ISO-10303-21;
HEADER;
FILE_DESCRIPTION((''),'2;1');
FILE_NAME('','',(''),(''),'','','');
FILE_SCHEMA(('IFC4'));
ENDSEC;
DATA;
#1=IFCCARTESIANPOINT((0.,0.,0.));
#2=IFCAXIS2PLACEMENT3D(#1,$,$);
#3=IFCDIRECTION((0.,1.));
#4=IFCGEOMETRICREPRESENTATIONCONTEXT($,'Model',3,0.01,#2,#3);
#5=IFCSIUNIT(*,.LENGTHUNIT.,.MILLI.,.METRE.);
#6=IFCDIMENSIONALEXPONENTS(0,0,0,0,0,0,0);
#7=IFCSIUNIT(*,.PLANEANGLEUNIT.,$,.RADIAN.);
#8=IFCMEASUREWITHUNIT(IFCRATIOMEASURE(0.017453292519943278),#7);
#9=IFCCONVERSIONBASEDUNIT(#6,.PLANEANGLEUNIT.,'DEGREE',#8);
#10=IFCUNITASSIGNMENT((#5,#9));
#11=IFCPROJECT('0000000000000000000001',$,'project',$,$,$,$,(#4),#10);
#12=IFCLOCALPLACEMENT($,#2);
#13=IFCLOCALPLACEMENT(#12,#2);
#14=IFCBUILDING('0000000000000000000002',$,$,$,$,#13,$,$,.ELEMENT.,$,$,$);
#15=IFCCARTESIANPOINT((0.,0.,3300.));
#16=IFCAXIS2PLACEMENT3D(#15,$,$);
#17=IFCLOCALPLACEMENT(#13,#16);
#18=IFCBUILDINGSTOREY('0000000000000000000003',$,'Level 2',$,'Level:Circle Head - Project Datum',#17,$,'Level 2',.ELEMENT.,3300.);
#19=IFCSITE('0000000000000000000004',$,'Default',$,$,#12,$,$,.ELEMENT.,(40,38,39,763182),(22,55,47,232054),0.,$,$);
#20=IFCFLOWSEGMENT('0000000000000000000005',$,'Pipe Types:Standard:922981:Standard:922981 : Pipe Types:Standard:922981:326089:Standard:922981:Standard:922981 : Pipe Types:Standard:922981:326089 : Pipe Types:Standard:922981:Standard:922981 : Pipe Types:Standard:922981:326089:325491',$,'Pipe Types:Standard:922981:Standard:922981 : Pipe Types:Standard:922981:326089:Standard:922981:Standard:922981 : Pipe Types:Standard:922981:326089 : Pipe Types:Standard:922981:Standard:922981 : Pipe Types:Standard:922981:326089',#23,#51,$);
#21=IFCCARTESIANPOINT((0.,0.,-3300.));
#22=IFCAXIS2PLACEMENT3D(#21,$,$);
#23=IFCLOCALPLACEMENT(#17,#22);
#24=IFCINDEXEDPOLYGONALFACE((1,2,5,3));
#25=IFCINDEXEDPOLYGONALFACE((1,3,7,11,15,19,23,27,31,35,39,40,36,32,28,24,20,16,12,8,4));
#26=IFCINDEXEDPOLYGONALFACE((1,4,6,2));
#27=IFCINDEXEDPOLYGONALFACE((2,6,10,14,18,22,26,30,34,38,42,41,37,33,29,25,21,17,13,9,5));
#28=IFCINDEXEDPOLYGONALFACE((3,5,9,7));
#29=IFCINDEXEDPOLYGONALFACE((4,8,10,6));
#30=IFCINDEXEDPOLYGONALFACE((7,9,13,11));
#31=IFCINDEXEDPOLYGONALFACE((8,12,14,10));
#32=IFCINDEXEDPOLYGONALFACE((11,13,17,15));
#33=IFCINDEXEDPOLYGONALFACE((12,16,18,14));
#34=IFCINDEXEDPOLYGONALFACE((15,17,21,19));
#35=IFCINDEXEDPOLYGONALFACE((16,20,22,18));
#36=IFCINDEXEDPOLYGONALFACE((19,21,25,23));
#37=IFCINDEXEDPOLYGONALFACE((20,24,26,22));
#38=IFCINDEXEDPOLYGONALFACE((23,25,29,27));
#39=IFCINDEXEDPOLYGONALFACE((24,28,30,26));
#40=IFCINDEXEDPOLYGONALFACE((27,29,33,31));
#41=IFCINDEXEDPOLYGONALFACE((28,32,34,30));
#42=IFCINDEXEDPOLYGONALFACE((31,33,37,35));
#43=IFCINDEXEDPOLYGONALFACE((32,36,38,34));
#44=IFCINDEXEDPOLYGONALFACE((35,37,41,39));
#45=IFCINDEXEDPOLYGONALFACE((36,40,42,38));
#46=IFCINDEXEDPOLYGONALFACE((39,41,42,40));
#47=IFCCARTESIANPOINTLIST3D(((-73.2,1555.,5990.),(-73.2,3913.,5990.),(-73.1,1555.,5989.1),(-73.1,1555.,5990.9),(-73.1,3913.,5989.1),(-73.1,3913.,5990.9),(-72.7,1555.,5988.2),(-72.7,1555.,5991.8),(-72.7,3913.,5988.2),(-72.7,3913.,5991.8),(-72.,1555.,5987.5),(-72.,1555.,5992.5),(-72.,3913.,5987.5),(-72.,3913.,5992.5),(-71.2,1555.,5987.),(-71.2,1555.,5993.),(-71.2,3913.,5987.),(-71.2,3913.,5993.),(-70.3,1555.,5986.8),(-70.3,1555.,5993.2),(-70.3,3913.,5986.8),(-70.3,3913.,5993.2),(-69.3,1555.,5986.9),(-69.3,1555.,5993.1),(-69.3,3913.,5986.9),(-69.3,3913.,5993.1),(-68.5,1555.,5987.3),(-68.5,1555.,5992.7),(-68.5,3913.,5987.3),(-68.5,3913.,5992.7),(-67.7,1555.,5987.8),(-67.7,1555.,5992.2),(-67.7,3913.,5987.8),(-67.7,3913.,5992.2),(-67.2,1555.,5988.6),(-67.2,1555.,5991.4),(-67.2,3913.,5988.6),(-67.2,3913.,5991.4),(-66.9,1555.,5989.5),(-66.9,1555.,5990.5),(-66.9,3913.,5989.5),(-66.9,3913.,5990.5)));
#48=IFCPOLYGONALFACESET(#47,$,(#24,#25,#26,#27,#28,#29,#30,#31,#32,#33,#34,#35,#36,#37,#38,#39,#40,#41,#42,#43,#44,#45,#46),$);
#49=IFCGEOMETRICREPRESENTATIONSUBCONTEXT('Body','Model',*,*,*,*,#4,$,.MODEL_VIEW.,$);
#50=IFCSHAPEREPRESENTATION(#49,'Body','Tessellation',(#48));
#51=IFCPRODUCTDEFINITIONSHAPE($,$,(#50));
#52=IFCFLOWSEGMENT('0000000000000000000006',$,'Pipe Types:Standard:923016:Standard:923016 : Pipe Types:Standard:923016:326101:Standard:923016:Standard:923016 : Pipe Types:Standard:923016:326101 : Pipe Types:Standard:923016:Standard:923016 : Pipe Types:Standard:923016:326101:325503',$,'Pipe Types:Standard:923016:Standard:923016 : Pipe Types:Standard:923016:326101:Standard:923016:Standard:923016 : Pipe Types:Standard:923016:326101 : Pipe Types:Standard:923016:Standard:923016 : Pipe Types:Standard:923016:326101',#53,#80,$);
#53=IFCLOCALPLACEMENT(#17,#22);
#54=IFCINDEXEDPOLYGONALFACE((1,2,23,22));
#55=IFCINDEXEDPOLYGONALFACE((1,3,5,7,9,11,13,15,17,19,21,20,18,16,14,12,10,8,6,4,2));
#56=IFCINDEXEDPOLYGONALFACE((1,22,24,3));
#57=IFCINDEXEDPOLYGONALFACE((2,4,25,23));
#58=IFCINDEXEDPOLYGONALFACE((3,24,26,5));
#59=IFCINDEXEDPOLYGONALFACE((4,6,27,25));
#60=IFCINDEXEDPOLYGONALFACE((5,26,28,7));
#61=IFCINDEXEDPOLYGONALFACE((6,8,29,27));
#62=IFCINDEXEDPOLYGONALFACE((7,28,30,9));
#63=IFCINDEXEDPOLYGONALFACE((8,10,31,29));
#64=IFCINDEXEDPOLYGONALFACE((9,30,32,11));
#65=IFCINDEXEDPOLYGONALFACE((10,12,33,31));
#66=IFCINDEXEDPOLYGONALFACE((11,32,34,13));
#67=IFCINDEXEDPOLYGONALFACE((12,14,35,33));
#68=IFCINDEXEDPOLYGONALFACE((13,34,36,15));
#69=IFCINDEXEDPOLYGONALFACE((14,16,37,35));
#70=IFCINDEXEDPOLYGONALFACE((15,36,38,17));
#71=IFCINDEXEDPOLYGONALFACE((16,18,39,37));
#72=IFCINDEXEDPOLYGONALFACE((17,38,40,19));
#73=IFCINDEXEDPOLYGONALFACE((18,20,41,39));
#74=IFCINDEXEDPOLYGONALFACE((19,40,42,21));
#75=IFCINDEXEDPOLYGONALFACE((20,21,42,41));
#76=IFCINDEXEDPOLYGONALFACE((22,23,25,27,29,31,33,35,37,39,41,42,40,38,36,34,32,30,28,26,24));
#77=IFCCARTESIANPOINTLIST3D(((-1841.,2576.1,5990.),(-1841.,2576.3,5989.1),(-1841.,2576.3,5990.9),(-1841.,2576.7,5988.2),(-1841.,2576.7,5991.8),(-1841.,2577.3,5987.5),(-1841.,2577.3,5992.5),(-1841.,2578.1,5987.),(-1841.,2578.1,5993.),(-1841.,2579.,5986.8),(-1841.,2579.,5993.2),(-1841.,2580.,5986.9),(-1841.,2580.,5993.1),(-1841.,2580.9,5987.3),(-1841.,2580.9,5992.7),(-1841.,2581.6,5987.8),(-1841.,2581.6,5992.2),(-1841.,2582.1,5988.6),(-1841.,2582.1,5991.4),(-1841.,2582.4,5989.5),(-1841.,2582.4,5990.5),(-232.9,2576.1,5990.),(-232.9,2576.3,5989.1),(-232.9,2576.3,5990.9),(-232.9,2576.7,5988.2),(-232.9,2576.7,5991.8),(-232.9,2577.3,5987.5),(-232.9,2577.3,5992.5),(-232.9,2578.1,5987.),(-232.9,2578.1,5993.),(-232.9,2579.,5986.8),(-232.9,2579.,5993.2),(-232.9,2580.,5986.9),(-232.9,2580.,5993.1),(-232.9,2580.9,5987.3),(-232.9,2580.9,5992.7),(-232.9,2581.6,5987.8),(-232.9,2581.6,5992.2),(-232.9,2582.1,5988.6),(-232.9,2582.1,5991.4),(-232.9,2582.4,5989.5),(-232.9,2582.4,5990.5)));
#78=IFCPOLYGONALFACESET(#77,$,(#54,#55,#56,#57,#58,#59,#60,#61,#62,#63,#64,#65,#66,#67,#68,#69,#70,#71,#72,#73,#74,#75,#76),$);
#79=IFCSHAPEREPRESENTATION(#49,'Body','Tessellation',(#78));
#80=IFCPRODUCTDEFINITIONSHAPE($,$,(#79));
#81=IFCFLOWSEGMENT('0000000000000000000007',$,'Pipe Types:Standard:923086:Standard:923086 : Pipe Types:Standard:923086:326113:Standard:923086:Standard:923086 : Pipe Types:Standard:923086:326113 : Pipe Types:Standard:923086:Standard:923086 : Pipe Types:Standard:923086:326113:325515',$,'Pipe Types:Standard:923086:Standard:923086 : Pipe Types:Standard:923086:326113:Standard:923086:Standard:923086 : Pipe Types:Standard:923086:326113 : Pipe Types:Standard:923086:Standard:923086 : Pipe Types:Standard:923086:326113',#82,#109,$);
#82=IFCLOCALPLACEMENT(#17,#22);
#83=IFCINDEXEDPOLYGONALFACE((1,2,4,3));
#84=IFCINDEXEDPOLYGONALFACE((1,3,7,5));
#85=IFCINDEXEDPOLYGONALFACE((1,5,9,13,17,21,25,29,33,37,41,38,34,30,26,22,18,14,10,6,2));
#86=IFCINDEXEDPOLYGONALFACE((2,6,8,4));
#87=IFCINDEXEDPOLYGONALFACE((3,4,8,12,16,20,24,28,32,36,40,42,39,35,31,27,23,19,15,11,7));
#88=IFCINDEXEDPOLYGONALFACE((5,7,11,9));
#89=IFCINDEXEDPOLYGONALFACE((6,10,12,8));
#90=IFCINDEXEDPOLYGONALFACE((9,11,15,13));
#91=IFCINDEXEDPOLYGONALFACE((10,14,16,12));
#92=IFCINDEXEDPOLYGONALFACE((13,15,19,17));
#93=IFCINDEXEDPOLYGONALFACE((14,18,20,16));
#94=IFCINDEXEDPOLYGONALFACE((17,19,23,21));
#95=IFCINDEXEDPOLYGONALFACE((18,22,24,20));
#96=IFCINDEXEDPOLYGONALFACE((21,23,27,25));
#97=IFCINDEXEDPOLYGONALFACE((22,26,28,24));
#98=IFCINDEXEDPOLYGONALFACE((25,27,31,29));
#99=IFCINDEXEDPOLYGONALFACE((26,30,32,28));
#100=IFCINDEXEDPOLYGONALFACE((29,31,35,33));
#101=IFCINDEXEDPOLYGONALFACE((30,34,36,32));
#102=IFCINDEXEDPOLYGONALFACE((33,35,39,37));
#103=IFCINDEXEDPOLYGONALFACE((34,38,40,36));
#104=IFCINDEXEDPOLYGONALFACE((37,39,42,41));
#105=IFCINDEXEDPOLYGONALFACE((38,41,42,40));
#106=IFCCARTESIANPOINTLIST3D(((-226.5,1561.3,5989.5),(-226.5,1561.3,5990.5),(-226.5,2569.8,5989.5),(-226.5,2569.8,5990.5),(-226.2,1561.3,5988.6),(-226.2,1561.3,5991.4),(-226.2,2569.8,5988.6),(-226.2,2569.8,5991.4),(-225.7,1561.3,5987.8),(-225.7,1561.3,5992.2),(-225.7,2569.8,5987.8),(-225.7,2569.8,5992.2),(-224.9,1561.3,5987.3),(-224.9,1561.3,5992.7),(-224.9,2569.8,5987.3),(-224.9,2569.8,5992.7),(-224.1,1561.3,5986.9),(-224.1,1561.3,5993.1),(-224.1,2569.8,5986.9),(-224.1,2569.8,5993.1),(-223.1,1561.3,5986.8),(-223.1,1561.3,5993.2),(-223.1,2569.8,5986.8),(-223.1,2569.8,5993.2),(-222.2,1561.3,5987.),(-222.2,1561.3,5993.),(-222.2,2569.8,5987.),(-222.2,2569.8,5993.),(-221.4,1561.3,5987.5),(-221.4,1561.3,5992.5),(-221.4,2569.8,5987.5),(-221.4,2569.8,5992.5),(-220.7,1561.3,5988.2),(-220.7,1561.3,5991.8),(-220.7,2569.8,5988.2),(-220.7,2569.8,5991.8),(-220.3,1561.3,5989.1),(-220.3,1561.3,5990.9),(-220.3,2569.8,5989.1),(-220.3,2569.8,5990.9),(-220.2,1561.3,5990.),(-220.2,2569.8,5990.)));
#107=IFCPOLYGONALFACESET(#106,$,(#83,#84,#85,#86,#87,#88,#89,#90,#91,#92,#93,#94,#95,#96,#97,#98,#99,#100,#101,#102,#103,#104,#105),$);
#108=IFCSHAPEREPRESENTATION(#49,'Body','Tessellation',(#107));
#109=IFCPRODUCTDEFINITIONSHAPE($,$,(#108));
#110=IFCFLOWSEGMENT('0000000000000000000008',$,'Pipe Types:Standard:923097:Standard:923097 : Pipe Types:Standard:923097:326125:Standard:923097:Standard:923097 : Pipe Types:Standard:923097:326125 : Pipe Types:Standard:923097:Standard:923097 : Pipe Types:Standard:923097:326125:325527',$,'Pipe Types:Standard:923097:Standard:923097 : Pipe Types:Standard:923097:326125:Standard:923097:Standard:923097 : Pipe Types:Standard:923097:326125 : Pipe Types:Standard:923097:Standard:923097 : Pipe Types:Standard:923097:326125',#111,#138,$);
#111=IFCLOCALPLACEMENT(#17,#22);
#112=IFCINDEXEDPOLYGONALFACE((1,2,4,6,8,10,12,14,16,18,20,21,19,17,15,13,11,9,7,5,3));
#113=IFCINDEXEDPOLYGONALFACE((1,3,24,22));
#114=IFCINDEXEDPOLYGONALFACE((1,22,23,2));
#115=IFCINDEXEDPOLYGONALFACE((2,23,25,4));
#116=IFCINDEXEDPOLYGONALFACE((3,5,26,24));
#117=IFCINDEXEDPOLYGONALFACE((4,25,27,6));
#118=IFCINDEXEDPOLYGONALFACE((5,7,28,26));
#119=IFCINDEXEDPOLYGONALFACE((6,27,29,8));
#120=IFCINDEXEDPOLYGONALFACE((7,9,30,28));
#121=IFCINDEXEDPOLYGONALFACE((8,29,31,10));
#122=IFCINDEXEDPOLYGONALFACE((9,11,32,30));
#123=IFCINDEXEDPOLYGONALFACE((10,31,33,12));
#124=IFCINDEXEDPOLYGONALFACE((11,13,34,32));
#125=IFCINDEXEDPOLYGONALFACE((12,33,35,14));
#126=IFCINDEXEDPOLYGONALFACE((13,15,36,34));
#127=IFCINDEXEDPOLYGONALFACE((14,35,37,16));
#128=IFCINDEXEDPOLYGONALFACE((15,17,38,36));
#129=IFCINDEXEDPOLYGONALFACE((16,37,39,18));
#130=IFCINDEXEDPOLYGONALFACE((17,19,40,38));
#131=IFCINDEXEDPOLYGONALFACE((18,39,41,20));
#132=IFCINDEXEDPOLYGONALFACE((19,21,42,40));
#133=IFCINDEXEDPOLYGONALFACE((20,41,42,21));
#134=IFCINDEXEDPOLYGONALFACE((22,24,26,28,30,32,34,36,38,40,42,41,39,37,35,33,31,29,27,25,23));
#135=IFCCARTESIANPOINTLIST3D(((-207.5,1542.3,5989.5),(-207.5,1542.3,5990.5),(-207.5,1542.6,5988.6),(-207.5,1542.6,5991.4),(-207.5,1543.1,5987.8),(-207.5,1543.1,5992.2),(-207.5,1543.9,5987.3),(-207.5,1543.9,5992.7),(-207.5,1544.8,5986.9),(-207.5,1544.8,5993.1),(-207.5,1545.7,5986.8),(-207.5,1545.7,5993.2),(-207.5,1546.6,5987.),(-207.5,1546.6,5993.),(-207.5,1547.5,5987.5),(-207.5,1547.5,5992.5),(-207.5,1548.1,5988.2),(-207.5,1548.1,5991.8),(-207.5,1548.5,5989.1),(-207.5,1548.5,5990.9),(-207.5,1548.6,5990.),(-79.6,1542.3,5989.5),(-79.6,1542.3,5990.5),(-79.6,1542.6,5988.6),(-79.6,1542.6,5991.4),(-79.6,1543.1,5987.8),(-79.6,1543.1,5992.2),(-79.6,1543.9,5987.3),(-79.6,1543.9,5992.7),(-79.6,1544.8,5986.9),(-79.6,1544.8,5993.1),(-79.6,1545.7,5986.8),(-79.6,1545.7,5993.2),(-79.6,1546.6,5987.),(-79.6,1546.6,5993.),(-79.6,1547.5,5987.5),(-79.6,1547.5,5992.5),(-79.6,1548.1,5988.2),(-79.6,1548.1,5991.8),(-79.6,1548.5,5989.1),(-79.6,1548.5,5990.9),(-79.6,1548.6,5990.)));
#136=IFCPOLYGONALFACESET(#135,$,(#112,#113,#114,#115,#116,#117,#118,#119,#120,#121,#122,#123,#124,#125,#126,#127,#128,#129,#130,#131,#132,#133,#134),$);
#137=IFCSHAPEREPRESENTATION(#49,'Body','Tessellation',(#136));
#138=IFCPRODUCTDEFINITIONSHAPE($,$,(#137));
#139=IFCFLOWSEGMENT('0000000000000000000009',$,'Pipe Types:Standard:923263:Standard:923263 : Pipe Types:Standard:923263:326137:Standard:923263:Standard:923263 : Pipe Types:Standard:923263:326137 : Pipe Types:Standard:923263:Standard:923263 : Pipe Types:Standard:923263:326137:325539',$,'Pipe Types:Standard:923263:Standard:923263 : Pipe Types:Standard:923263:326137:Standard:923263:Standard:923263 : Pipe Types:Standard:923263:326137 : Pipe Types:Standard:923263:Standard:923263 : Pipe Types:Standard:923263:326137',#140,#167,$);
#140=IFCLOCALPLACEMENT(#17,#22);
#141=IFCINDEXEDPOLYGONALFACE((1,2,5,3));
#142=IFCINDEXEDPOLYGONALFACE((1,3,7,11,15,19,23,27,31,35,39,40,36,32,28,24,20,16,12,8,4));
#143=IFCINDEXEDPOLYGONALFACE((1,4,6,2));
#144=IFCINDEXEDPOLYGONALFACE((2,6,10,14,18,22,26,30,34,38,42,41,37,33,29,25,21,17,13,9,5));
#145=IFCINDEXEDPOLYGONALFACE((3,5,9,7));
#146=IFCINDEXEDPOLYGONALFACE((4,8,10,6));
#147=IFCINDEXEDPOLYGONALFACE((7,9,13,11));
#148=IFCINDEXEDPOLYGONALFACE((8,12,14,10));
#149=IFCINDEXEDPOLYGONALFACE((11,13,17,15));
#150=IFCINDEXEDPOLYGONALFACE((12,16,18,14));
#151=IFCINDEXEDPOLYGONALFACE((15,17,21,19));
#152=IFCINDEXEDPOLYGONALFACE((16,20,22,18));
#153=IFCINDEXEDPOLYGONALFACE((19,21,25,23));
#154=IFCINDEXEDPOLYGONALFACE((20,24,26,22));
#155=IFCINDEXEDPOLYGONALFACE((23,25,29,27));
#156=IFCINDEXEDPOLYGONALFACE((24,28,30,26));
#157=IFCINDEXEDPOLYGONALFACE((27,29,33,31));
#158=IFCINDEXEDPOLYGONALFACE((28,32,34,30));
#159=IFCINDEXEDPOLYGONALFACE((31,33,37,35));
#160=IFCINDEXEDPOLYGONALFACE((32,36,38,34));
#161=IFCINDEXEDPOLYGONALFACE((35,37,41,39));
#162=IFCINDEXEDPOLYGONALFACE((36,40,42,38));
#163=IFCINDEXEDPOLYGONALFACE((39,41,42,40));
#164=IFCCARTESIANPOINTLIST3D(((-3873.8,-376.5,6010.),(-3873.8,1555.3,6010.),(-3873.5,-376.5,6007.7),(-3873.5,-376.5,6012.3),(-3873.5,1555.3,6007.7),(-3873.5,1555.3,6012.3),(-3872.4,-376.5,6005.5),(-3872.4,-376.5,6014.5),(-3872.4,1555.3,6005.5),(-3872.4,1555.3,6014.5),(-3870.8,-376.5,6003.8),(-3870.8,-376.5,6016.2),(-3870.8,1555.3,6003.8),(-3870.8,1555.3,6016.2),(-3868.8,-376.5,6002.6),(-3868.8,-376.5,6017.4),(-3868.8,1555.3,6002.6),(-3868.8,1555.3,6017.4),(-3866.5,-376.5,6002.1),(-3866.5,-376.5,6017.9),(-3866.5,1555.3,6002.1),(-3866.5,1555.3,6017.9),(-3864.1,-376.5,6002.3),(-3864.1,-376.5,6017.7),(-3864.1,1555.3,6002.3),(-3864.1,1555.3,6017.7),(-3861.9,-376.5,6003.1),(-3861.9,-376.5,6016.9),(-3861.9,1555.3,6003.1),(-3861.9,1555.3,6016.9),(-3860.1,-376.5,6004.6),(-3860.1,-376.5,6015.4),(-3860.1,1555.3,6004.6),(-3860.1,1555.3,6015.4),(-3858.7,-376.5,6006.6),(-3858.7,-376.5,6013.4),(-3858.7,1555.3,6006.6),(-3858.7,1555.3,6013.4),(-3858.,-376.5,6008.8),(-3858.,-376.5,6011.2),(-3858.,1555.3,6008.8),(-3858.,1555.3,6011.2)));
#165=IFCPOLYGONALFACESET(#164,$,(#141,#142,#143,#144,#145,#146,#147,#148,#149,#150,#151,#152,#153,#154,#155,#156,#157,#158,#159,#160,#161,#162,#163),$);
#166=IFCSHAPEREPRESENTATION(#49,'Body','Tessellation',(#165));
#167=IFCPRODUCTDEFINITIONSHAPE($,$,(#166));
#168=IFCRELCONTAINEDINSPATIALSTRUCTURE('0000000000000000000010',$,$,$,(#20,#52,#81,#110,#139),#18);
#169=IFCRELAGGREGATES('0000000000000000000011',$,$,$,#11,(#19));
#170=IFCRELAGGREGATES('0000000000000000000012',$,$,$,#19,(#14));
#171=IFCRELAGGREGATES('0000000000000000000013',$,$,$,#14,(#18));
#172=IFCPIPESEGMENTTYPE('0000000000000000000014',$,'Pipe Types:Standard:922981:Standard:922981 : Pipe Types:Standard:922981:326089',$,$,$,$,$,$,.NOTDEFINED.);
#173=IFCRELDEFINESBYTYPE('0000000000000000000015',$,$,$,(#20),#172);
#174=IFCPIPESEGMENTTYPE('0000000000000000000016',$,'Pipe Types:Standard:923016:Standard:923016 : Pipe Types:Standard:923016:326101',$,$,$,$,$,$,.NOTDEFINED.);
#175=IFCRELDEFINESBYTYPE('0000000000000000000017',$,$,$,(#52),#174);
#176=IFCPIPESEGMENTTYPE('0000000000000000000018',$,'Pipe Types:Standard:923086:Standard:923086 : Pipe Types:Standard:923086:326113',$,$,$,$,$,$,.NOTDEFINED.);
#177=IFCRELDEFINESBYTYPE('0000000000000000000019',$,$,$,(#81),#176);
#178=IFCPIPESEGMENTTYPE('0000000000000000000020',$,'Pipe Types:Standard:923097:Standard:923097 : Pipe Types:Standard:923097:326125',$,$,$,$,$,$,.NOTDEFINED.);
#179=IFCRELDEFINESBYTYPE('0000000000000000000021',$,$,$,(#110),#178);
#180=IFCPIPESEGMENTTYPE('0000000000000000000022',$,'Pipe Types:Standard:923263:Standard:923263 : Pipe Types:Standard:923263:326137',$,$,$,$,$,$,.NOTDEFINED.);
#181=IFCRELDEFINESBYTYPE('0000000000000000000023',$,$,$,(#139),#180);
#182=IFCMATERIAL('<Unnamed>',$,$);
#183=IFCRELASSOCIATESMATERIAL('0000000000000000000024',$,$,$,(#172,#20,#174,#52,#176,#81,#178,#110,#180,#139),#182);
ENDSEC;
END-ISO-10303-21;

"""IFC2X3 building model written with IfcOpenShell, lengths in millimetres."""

from ifc_helpers import new_model, entity, si_unit, converted_unit, direction, frame, origin, origin_2d_with_axis, place, context, subcontext, project, spatial, circle, extrude, source, transform, mapped, material, type_object, type_shapes, element, save


model = new_model("IFC2X3")

# Units and contexts
model_context = context("Model", 3, precision=0.01, world=origin(), true_north=direction((0.0, 1.0)))
body_context = subcontext(model_context, "Body", "Model", "MODEL_VIEW")
ifc_project = project(units=[si_unit("LENGTHUNIT", "METRE", prefix="MILLI"), converted_unit("PLANEANGLEUNIT", "DEGREE", entity("IfcRatioMeasure", 0.017453292519943278), si_unit("PLANEANGLEUNIT", "RADIAN"), dimensions=[0, 0, 0, 0, 0, 0, 0])], contexts=[model_context])

# Site, building, storey
site_placement = place(None, origin())
site = spatial("IfcSite", under=ifc_project, at=site_placement, Name="Default", CompositionType="ELEMENT", RefLatitude=(40, 38, 39, 763182), RefLongitude=(22, 55, 47, 232054), RefElevation=0.0)
building_placement = place(site_placement, origin())
building = spatial("IfcBuilding", under=site, at=building_placement, CompositionType="ELEMENT")
storey_placement = place(building_placement, frame((0.0, 0.0, 3300.0)))
storey = spatial("IfcBuildingStorey", under=building, at=storey_placement, Name="Level 2", ObjectType="Level:Circle Head - Project Datum", LongName="Level 2", CompositionType="ELEMENT", Elevation=3300.0)

# Flow segments
ifc_material = material(Name="<Unnamed>")
pipe_segment_type_1 = type_object("IfcPipeSegmentType", Name="Pipe Types:Standard:922981:Standard:922981 : Pipe Types:Standard:922981:326089", PredefinedType="NOTDEFINED", material=ifc_material)
shared_shape_1 = source(origin(), body_context, "Body", "SweptSolid", [
    extrude(circle(Radius=3.2, at=origin_2d_with_axis()), frame((-70.1, 1555.0, 5990.0), z_axis=(0.0, 1.0, 0.0), x_axis=(-1.0, 0.0, 0.0)), (0.0, 0.0, 1.0), 2358.0),
])
type_shapes(pipe_segment_type_1, [shared_shape_1])
flow_segment_1_placement = place(storey_placement, frame((0.0, 0.0, -3300.0)))
element("IfcFlowSegment", 1, at=flow_segment_1_placement, inside=storey, type_object=pipe_segment_type_1, material=ifc_material, Name="Pipe Types:Standard:922981:Standard:922981 : Pipe Types:Standard:922981:326089:Standard:922981:Standard:922981 : Pipe Types:Standard:922981:326089 : Pipe Types:Standard:922981:Standard:922981 : Pipe Types:Standard:922981:326089:325491", ObjectType="Pipe Types:Standard:922981:Standard:922981 : Pipe Types:Standard:922981:326089:Standard:922981:Standard:922981 : Pipe Types:Standard:922981:326089 : Pipe Types:Standard:922981:Standard:922981 : Pipe Types:Standard:922981:326089", context=body_context, shape_type="MappedRepresentation", body=[
    mapped(shared_shape_1, transform((0.0, 0.0, 0.0), scale=1.0)),
])
pipe_segment_type_2 = type_object("IfcPipeSegmentType", Name="Pipe Types:Standard:923016:Standard:923016 : Pipe Types:Standard:923016:326101", PredefinedType="NOTDEFINED", material=ifc_material)
shared_shape_2 = source(origin(), body_context, "Body", "SweptSolid", [
    extrude(circle(Radius=3.2, at=origin_2d_with_axis()), frame((-1841.0, 2579.3, 5990.0), z_axis=(1.0, 0.0, 0.0), x_axis=(0.0, -1.0, 0.0)), (0.0, 0.0, 1.0), 1608.1),
])
type_shapes(pipe_segment_type_2, [shared_shape_2])
flow_segment_2_placement = place(storey_placement, frame((0.0, 0.0, -3300.0)))
element("IfcFlowSegment", 2, at=flow_segment_2_placement, inside=storey, type_object=pipe_segment_type_2, material=ifc_material, Name="Pipe Types:Standard:923016:Standard:923016 : Pipe Types:Standard:923016:326101:Standard:923016:Standard:923016 : Pipe Types:Standard:923016:326101 : Pipe Types:Standard:923016:Standard:923016 : Pipe Types:Standard:923016:326101:325503", ObjectType="Pipe Types:Standard:923016:Standard:923016 : Pipe Types:Standard:923016:326101:Standard:923016:Standard:923016 : Pipe Types:Standard:923016:326101 : Pipe Types:Standard:923016:Standard:923016 : Pipe Types:Standard:923016:326101", context=body_context, shape_type="MappedRepresentation", body=[
    mapped(shared_shape_2, transform((0.0, 0.0, 0.0), scale=1.0)),
])
pipe_segment_type_3 = type_object("IfcPipeSegmentType", Name="Pipe Types:Standard:923086:Standard:923086 : Pipe Types:Standard:923086:326113", PredefinedType="NOTDEFINED", material=ifc_material)
shared_shape_3 = source(origin(), body_context, "Body", "SweptSolid", [
    extrude(circle(Radius=3.2, at=origin_2d_with_axis()), frame((-223.4, 1561.3, 5990.0), z_axis=(0.0, 1.0, 0.0), x_axis=(1.0, 0.0, 0.0)), (0.0, 0.0, 1.0), 1008.4),
])
type_shapes(pipe_segment_type_3, [shared_shape_3])
flow_segment_3_placement = place(storey_placement, frame((0.0, 0.0, -3300.0)))
element("IfcFlowSegment", 3, at=flow_segment_3_placement, inside=storey, type_object=pipe_segment_type_3, material=ifc_material, Name="Pipe Types:Standard:923086:Standard:923086 : Pipe Types:Standard:923086:326113:Standard:923086:Standard:923086 : Pipe Types:Standard:923086:326113 : Pipe Types:Standard:923086:Standard:923086 : Pipe Types:Standard:923086:326113:325515", ObjectType="Pipe Types:Standard:923086:Standard:923086 : Pipe Types:Standard:923086:326113:Standard:923086:Standard:923086 : Pipe Types:Standard:923086:326113 : Pipe Types:Standard:923086:Standard:923086 : Pipe Types:Standard:923086:326113", context=body_context, shape_type="MappedRepresentation", body=[
    mapped(shared_shape_3, transform((0.0, 0.0, 0.0), scale=1.0)),
])
pipe_segment_type_4 = type_object("IfcPipeSegmentType", Name="Pipe Types:Standard:923097:Standard:923097 : Pipe Types:Standard:923097:326125", PredefinedType="NOTDEFINED", material=ifc_material)
shared_shape_4 = source(origin(), body_context, "Body", "SweptSolid", [
    extrude(circle(Radius=3.2, at=origin_2d_with_axis()), frame((-207.5, 1545.5, 5990.0), z_axis=(1.0, 0.0, 0.0), x_axis=(0.0, 1.0, 0.0)), (0.0, 0.0, 1.0), 127.9),
])
type_shapes(pipe_segment_type_4, [shared_shape_4])
flow_segment_4_placement = place(storey_placement, frame((0.0, 0.0, -3300.0)))
element("IfcFlowSegment", 4, at=flow_segment_4_placement, inside=storey, type_object=pipe_segment_type_4, material=ifc_material, Name="Pipe Types:Standard:923097:Standard:923097 : Pipe Types:Standard:923097:326125:Standard:923097:Standard:923097 : Pipe Types:Standard:923097:326125 : Pipe Types:Standard:923097:Standard:923097 : Pipe Types:Standard:923097:326125:325527", ObjectType="Pipe Types:Standard:923097:Standard:923097 : Pipe Types:Standard:923097:326125:Standard:923097:Standard:923097 : Pipe Types:Standard:923097:326125 : Pipe Types:Standard:923097:Standard:923097 : Pipe Types:Standard:923097:326125", context=body_context, shape_type="MappedRepresentation", body=[
    mapped(shared_shape_4, transform((0.0, 0.0, 0.0), scale=1.0)),
])
pipe_segment_type_5 = type_object("IfcPipeSegmentType", Name="Pipe Types:Standard:923263:Standard:923263 : Pipe Types:Standard:923263:326137", PredefinedType="NOTDEFINED", material=ifc_material)
shared_shape_5 = source(origin(), body_context, "Body", "SweptSolid", [
    extrude(circle(Radius=7.9, at=origin_2d_with_axis()), frame((-3865.9, -376.5, 6010.0), z_axis=(0.0, 1.0, 0.0), x_axis=(-1.0, 0.0, 0.0)), (0.0, 0.0, 1.0), 1931.7),
])
type_shapes(pipe_segment_type_5, [shared_shape_5])
flow_segment_5_placement = place(storey_placement, frame((0.0, 0.0, -3300.0)))
element("IfcFlowSegment", 5, at=flow_segment_5_placement, inside=storey, type_object=pipe_segment_type_5, material=ifc_material, Name="Pipe Types:Standard:923263:Standard:923263 : Pipe Types:Standard:923263:326137:Standard:923263:Standard:923263 : Pipe Types:Standard:923263:326137 : Pipe Types:Standard:923263:Standard:923263 : Pipe Types:Standard:923263:326137:325539", ObjectType="Pipe Types:Standard:923263:Standard:923263 : Pipe Types:Standard:923263:326137:Standard:923263:Standard:923263 : Pipe Types:Standard:923263:326137 : Pipe Types:Standard:923263:Standard:923263 : Pipe Types:Standard:923263:326137", context=body_context, shape_type="MappedRepresentation", body=[
    mapped(shared_shape_5, transform((0.0, 0.0, 0.0), scale=1.0)),
])

save(model, "model.ifc")
